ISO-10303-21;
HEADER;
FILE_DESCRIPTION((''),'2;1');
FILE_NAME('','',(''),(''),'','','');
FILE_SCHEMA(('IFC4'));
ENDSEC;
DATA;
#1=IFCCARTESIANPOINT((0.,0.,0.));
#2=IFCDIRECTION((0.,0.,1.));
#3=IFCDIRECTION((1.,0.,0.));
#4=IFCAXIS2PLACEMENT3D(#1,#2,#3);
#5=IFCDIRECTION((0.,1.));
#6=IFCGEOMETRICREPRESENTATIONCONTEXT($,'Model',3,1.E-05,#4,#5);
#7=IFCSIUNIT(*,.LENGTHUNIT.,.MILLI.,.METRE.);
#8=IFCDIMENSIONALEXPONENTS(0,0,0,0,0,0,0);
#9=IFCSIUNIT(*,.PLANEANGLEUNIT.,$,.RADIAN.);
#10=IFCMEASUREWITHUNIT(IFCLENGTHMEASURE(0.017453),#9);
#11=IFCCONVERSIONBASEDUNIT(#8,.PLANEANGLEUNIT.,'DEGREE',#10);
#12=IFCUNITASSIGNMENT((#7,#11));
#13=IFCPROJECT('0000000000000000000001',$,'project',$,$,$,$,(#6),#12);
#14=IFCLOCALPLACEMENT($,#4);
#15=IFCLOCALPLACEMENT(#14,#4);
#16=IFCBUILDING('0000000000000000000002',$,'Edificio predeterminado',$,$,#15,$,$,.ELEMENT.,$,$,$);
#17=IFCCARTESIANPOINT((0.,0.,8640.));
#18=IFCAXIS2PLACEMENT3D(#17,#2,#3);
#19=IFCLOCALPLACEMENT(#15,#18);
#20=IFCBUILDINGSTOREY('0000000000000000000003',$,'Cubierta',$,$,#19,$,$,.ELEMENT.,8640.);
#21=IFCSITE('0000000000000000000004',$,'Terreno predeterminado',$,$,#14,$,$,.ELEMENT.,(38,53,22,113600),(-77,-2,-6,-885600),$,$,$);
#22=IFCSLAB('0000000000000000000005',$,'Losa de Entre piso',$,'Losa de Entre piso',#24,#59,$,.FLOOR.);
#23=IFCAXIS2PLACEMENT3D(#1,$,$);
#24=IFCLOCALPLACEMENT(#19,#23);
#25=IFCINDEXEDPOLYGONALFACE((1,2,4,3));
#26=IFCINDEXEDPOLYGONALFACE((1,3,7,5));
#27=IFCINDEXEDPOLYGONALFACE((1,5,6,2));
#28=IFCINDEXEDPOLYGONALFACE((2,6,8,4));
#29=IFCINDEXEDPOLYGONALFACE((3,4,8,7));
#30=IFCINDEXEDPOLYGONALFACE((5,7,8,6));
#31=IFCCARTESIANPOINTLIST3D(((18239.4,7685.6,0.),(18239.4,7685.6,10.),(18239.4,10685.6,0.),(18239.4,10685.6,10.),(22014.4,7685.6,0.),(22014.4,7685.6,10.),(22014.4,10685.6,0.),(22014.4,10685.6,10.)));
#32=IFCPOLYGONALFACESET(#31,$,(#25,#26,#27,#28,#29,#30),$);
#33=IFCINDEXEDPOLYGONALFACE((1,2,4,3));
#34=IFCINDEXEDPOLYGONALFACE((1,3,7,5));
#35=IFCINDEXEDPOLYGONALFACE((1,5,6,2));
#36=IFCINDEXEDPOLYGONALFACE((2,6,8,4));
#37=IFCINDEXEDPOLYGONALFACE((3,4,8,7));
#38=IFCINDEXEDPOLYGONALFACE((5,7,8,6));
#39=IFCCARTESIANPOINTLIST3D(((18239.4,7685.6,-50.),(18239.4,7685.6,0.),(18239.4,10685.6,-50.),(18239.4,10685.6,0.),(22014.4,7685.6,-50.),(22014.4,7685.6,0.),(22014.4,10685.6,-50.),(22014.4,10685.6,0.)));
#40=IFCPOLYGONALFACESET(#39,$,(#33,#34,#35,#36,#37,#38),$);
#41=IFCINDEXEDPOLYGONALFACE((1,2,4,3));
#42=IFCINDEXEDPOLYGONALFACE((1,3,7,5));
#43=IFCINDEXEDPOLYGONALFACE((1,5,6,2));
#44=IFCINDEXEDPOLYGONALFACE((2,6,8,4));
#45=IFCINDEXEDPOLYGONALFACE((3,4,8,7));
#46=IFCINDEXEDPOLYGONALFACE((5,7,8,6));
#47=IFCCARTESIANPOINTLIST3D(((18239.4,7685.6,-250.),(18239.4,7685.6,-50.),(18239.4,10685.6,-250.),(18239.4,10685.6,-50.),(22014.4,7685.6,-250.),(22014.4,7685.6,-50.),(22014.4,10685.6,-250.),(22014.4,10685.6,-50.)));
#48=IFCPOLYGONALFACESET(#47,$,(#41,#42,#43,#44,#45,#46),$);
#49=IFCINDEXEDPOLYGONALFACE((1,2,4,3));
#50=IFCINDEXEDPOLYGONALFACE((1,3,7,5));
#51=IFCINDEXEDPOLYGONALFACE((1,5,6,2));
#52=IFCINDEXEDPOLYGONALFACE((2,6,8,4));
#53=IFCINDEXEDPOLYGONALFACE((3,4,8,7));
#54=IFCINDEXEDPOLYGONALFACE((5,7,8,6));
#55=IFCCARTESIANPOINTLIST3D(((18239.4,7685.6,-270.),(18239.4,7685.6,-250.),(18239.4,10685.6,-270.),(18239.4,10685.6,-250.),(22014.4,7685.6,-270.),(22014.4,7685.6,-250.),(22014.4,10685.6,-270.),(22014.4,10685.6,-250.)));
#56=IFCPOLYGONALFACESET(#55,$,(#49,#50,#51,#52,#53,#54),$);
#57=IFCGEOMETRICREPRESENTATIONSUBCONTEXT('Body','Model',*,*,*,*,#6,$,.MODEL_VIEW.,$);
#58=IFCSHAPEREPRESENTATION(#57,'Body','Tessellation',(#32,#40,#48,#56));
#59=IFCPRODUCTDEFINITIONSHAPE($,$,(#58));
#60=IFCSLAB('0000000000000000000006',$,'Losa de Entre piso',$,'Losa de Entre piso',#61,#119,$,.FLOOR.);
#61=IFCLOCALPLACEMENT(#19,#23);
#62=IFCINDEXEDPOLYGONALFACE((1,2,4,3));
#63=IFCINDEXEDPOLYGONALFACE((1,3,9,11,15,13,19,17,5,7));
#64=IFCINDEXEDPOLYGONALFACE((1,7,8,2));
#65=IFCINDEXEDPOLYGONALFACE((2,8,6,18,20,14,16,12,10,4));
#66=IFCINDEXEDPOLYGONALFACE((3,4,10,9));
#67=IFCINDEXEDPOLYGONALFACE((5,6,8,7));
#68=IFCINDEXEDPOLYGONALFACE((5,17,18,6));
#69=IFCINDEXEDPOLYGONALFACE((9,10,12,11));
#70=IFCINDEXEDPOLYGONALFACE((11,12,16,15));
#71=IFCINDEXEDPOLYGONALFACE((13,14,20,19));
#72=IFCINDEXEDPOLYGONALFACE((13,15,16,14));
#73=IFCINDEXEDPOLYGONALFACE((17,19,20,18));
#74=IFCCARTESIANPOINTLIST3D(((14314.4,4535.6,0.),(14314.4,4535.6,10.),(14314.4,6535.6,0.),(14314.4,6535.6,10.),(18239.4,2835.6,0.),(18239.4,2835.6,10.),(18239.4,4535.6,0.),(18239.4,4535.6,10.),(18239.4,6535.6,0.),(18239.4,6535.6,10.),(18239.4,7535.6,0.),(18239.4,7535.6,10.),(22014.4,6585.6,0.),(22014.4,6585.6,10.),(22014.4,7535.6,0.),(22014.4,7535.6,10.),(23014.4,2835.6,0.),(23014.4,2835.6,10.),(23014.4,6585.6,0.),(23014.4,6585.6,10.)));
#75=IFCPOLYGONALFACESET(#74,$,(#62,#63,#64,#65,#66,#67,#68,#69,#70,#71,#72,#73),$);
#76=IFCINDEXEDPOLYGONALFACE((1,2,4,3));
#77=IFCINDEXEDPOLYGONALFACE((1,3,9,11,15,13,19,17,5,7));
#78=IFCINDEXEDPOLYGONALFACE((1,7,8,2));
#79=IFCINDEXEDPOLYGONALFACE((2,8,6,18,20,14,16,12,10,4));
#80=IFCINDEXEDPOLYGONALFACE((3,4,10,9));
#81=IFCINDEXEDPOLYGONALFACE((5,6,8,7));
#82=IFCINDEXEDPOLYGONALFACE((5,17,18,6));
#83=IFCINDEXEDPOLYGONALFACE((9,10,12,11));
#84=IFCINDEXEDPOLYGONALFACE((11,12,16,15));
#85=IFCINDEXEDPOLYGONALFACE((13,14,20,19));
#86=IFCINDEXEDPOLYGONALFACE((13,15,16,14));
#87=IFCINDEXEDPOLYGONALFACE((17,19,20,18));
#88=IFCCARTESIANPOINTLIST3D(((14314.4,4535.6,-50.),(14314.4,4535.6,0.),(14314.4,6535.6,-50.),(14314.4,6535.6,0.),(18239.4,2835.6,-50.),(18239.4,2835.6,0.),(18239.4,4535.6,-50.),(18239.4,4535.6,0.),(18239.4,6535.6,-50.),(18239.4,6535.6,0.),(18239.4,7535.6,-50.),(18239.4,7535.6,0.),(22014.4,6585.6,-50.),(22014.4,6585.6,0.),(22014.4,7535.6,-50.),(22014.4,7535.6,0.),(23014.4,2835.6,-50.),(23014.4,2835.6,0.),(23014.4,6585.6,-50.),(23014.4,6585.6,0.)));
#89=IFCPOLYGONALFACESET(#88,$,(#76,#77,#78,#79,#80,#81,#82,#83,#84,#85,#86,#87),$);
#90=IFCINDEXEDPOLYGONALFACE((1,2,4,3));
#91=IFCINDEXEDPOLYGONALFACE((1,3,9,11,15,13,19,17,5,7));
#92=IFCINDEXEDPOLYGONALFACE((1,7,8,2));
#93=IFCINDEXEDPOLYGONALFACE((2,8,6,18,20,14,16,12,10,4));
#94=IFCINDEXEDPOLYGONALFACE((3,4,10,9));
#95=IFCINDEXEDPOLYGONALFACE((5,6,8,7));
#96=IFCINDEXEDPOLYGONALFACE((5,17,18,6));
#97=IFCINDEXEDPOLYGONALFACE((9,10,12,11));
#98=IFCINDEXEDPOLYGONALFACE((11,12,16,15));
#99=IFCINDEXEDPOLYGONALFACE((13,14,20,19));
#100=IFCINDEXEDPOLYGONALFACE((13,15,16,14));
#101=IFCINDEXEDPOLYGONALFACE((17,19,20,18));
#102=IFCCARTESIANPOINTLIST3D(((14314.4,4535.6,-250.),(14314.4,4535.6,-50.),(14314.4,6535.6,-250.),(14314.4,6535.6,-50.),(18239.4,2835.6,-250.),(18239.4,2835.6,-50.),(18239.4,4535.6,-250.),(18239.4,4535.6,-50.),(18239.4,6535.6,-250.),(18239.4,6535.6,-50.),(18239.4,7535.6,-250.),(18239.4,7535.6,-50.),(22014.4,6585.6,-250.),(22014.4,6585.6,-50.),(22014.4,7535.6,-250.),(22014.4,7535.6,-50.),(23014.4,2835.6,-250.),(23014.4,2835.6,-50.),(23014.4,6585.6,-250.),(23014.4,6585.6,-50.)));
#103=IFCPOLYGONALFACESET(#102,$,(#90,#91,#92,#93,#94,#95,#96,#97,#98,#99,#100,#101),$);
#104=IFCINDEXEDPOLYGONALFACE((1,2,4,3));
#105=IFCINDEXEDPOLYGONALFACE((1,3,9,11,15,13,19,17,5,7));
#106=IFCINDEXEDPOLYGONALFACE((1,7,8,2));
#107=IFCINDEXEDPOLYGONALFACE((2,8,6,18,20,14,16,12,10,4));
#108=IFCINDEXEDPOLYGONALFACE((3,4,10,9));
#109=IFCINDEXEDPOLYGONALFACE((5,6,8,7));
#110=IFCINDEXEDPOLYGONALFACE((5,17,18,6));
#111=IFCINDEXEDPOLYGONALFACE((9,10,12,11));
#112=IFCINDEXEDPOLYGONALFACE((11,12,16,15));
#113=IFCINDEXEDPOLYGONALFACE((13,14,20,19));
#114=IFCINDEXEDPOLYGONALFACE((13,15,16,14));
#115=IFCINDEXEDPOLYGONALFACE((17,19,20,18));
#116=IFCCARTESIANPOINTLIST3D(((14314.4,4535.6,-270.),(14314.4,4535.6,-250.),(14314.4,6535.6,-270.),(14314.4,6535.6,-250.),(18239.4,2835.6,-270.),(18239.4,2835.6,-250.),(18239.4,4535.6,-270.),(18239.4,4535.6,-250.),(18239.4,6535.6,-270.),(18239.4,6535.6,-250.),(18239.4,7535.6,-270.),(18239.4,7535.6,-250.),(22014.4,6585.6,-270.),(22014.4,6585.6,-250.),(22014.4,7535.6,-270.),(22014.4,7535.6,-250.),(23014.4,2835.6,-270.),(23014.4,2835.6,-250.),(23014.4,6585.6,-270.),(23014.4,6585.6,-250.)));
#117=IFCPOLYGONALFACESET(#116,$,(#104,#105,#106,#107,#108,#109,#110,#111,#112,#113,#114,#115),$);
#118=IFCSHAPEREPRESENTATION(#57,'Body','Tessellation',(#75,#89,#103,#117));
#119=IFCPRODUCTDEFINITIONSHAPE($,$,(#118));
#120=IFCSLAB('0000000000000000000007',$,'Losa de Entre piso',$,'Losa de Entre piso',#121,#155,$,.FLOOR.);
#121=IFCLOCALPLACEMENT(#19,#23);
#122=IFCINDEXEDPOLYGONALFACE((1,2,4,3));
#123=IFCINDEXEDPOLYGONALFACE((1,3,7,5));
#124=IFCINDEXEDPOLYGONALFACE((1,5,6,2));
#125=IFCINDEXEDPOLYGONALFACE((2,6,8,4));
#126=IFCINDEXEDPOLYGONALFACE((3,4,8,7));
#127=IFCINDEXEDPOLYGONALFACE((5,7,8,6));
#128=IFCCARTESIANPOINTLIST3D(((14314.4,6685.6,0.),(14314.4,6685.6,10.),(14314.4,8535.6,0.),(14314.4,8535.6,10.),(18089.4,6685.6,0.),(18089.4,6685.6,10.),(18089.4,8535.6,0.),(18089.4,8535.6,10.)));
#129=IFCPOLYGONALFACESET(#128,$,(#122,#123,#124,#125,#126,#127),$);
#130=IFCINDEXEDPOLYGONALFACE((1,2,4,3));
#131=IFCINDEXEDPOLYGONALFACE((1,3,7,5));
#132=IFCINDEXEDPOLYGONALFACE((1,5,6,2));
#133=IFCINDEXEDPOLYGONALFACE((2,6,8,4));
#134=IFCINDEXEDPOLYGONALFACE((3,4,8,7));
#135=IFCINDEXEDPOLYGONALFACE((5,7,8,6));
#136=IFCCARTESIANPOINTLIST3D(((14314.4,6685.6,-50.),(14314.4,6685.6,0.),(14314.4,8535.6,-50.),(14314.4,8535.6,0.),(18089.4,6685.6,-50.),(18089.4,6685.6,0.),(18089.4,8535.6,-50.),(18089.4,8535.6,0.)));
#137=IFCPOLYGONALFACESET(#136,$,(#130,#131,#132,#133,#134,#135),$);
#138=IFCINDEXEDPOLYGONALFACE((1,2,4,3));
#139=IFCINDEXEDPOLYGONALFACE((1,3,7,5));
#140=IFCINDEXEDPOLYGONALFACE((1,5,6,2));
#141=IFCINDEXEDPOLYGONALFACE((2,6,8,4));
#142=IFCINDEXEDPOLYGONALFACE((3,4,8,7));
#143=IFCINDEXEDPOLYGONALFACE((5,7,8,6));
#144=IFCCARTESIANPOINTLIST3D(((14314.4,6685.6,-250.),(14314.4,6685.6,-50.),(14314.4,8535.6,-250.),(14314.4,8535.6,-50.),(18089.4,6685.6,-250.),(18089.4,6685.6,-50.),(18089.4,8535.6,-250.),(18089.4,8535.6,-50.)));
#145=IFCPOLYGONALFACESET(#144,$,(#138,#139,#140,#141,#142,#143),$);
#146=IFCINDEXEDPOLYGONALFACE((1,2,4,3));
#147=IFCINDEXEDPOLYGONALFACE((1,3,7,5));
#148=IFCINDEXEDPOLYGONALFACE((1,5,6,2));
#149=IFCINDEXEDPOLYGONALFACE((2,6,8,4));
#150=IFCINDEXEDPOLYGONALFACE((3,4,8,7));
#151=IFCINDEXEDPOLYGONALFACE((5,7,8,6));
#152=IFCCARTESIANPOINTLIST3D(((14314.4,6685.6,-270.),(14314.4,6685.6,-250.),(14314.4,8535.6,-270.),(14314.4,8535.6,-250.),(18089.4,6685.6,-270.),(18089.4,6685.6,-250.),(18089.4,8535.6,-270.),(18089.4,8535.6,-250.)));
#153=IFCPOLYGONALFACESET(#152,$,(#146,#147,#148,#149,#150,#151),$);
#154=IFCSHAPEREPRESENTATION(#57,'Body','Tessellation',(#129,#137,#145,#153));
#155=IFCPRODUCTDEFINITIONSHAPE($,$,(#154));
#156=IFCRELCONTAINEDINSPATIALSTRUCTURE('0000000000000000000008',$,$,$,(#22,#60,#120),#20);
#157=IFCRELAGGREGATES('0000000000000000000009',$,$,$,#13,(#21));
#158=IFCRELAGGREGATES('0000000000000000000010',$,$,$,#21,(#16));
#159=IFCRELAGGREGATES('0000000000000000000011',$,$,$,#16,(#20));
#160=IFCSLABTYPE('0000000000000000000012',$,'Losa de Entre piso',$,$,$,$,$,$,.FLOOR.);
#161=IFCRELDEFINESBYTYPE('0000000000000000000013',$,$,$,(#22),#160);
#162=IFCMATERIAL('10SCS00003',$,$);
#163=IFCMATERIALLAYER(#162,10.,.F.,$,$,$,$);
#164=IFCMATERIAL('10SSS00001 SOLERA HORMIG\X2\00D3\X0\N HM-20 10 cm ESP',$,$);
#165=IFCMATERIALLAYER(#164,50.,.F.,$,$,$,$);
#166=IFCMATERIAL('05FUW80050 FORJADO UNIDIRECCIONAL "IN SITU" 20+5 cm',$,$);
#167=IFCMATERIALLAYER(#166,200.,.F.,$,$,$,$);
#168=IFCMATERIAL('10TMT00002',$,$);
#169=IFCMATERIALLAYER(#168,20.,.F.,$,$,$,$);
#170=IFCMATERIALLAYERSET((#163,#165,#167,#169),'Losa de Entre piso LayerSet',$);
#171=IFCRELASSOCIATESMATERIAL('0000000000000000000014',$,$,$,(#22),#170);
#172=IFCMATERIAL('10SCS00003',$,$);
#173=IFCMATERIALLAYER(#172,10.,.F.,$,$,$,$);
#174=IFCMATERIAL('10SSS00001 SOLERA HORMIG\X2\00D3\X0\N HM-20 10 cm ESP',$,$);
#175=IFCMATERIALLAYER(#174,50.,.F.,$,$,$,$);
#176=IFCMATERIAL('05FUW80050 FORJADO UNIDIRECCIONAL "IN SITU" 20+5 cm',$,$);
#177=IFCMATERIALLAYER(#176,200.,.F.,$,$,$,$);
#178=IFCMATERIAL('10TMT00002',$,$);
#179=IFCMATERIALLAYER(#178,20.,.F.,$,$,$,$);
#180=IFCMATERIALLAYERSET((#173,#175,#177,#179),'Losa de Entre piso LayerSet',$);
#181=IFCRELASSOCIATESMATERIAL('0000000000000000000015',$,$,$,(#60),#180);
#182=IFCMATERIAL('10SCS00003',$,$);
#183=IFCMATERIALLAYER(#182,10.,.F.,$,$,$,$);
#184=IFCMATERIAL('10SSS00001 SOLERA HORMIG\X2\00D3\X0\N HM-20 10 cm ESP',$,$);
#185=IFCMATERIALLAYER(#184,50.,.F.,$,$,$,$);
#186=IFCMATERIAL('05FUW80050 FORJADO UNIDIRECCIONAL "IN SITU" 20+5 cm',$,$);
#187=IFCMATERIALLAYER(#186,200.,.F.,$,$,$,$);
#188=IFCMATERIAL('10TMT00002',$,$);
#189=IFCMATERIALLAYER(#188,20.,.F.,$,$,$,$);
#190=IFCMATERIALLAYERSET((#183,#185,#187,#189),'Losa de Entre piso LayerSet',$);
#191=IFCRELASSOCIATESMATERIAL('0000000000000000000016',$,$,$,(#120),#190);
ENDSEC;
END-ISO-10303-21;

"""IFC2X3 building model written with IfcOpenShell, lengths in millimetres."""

from ifc_helpers import new_model, entity, si_unit, converted_unit, direction, frame, origin_with_axes, place, context, subcontext, project, spatial, polyline, outline, extrude, material, layer, layer_set, layer_usage, type_object, element, save


model = new_model("IFC2X3")

# Units and contexts
model_context = context("Model", 3, precision=1e-05, world=origin_with_axes(), true_north=direction((0.0, 1.0)))
body_context = subcontext(model_context, "Body", "Model", "MODEL_VIEW")
ifc_project = project(units=[si_unit("LENGTHUNIT", "METRE", prefix="MILLI"), converted_unit("PLANEANGLEUNIT", "DEGREE", entity("IfcLengthMeasure", 0.017453), si_unit("PLANEANGLEUNIT", "RADIAN"), dimensions=[0, 0, 0, 0, 0, 0, 0])], contexts=[model_context])

# Site, building, storey
site_placement = place(None, origin_with_axes())
site = spatial("IfcSite", under=ifc_project, at=site_placement, Name="Terreno predeterminado", CompositionType="ELEMENT", RefLatitude=(38, 53, 22, 113600), RefLongitude=(-77, -2, -6, -885600))
building_placement = place(site_placement, origin_with_axes())
building = spatial("IfcBuilding", under=site, at=building_placement, Name="Edificio predeterminado", CompositionType="ELEMENT")
storey_placement = place(building_placement, frame((0.0, 0.0, 8640.0), z_axis=(0.0, 0.0, 1.0), x_axis=(1.0, 0.0, 0.0)))
storey = spatial("IfcBuildingStorey", under=building, at=storey_placement, Name="Cubierta", CompositionType="ELEMENT", Elevation=8640.0)

# Slabs
ifc_material_1 = material(Name="10SCS00003")
ifc_layer_1 = layer(ifc_material_1, 10.0, ventilated=False)
ifc_material_2 = material(Name="10SSS00001 SOLERA HORMIGÓN HM-20 10 cm ESP")
ifc_layer_2 = layer(ifc_material_2, 50.0, ventilated=False)
ifc_material_3 = material(Name="05FUW80050 FORJADO UNIDIRECCIONAL \"IN SITU\" 20+5 cm")
ifc_layer_3 = layer(ifc_material_3, 200.0, ventilated=False)
ifc_material_4 = material(Name="10TMT00002")
ifc_layer_4 = layer(ifc_material_4, 20.0, ventilated=False)
ifc_layer_set_1 = layer_set([ifc_layer_1, ifc_layer_2, ifc_layer_3, ifc_layer_4], Name="Losa de Entre piso LayerSet")
ifc_layer_usage_1 = layer_usage(ifc_layer_set_1, "AXIS3", "NEGATIVE", 0.0)
slab_type = type_object("IfcSlabType", Name="Losa de Entre piso", PredefinedType="FLOOR")
slab_1_placement = place(storey_placement, frame((0.0, 0.0, -8640.0), z_axis=(0.0, 0.0, 1.0), x_axis=(1.0, 0.0, 0.0)))
element("IfcSlab", 1, at=slab_1_placement, inside=storey, type_object=slab_type, material=ifc_layer_usage_1, Name="Losa de Entre piso", ObjectType="Losa de Entre piso", PredefinedType="FLOOR", context=body_context, shape_type="SweptSolid", body=[
    extrude(outline(polyline([(0.0, 3000.0), (3775.0, 3000.0), (3775.0, 0.0), (0.0, 0.0), (0.0, 3000.0)])), frame((22014.4, 7685.6, 8640.0), z_axis=(0.0, 0.0, -1.0), x_axis=(-1.0, 0.0, 0.0)), (0.0, 0.0, -1.0), 10.0),
    extrude(outline(polyline([(0.0, 3000.0), (3775.0, 3000.0), (3775.0, 0.0), (0.0, 0.0), (0.0, 3000.0)])), frame((22014.4, 7685.6, 8590.0), z_axis=(0.0, 0.0, -1.0), x_axis=(-1.0, 0.0, 0.0)), (0.0, 0.0, -1.0), 50.0),
    extrude(outline(polyline([(0.0, 3000.0), (3775.0, 3000.0), (3775.0, 0.0), (0.0, 0.0), (0.0, 3000.0)])), frame((22014.4, 7685.6, 8390.0), z_axis=(0.0, 0.0, -1.0), x_axis=(-1.0, 0.0, 0.0)), (0.0, 0.0, -1.0), 200.0),
    extrude(outline(polyline([(0.0, 3000.0), (3775.0, 3000.0), (3775.0, 0.0), (0.0, 0.0), (0.0, 3000.0)])), frame((22014.4, 7685.6, 8370.0), z_axis=(0.0, 0.0, -1.0), x_axis=(-1.0, 0.0, 0.0)), (0.0, 0.0, -1.0), 20.0),
])
ifc_material_5 = material(Name="10SCS00003")
ifc_layer_5 = layer(ifc_material_5, 10.0, ventilated=False)
ifc_material_6 = material(Name="10SSS00001 SOLERA HORMIGÓN HM-20 10 cm ESP")
ifc_layer_6 = layer(ifc_material_6, 50.0, ventilated=False)
ifc_material_7 = material(Name="05FUW80050 FORJADO UNIDIRECCIONAL \"IN SITU\" 20+5 cm")
ifc_layer_7 = layer(ifc_material_7, 200.0, ventilated=False)
ifc_material_8 = material(Name="10TMT00002")
ifc_layer_8 = layer(ifc_material_8, 20.0, ventilated=False)
ifc_layer_set_2 = layer_set([ifc_layer_5, ifc_layer_6, ifc_layer_7, ifc_layer_8], Name="Losa de Entre piso LayerSet")
ifc_layer_usage_2 = layer_usage(ifc_layer_set_2, "AXIS3", "NEGATIVE", 0.0)
slab_2_placement = place(storey_placement, frame((0.0, 0.0, -8640.0), z_axis=(0.0, 0.0, 1.0), x_axis=(1.0, 0.0, 0.0)))
element("IfcSlab", 2, at=slab_2_placement, inside=storey, material=ifc_layer_usage_2, Name="Losa de Entre piso", ObjectType="Losa de Entre piso", PredefinedType="FLOOR", context=body_context, shape_type="SweptSolid", body=[
    extrude(outline(polyline([(0.0, 1000.0), (-3925.0, 1000.0), (-3925.0, 3000.0), (0.0, 3000.0), (0.0, 4700.0), (4775.0, 4700.0), (4775.0, 950.0), (3775.0, 950.0), (3775.0, 0.0), (0.0, 0.0), (0.0, 1000.0)])), frame((18239.4, 7535.6, 8640.0), z_axis=(0.0, 0.0, -1.0), x_axis=(1.0, 0.0, 0.0)), (0.0, 0.0, -1.0), 10.0),
    extrude(outline(polyline([(0.0, 1000.0), (-3925.0, 1000.0), (-3925.0, 3000.0), (0.0, 3000.0), (0.0, 4700.0), (4775.0, 4700.0), (4775.0, 950.0), (3775.0, 950.0), (3775.0, 0.0), (0.0, 0.0), (0.0, 1000.0)])), frame((18239.4, 7535.6, 8590.0), z_axis=(0.0, 0.0, -1.0), x_axis=(1.0, 0.0, 0.0)), (0.0, 0.0, -1.0), 50.0),
    extrude(outline(polyline([(0.0, 1000.0), (-3925.0, 1000.0), (-3925.0, 3000.0), (0.0, 3000.0), (0.0, 4700.0), (4775.0, 4700.0), (4775.0, 950.0), (3775.0, 950.0), (3775.0, 0.0), (0.0, 0.0), (0.0, 1000.0)])), frame((18239.4, 7535.6, 8390.0), z_axis=(0.0, 0.0, -1.0), x_axis=(1.0, 0.0, 0.0)), (0.0, 0.0, -1.0), 200.0),
    extrude(outline(polyline([(0.0, 1000.0), (-3925.0, 1000.0), (-3925.0, 3000.0), (0.0, 3000.0), (0.0, 4700.0), (4775.0, 4700.0), (4775.0, 950.0), (3775.0, 950.0), (3775.0, 0.0), (0.0, 0.0), (0.0, 1000.0)])), frame((18239.4, 7535.6, 8370.0), z_axis=(0.0, 0.0, -1.0), x_axis=(1.0, 0.0, 0.0)), (0.0, 0.0, -1.0), 20.0),
])
ifc_material_9 = material(Name="10SCS00003")
ifc_layer_9 = layer(ifc_material_9, 10.0, ventilated=False)
ifc_material_10 = material(Name="10SSS00001 SOLERA HORMIGÓN HM-20 10 cm ESP")
ifc_layer_10 = layer(ifc_material_10, 50.0, ventilated=False)
ifc_material_11 = material(Name="05FUW80050 FORJADO UNIDIRECCIONAL \"IN SITU\" 20+5 cm")
ifc_layer_11 = layer(ifc_material_11, 200.0, ventilated=False)
ifc_material_12 = material(Name="10TMT00002")
ifc_layer_12 = layer(ifc_material_12, 20.0, ventilated=False)
ifc_layer_set_3 = layer_set([ifc_layer_9, ifc_layer_10, ifc_layer_11, ifc_layer_12], Name="Losa de Entre piso LayerSet")
ifc_layer_usage_3 = layer_usage(ifc_layer_set_3, "AXIS3", "NEGATIVE", 0.0)
slab_3_placement = place(storey_placement, frame((0.0, 0.0, -8640.0), z_axis=(0.0, 0.0, 1.0), x_axis=(1.0, 0.0, 0.0)))
element("IfcSlab", 3, at=slab_3_placement, inside=storey, material=ifc_layer_usage_3, Name="Losa de Entre piso", ObjectType="Losa de Entre piso", PredefinedType="FLOOR", context=body_context, shape_type="SweptSolid", body=[
    extrude(outline(polyline([(0.0, 1850.0), (3775.0, 1850.0), (3775.0, 0.0), (0.0, 0.0), (0.0, 1850.0)])), frame((18089.4, 6685.6, 8640.0), z_axis=(0.0, 0.0, -1.0), x_axis=(-1.0, 0.0, 0.0)), (0.0, 0.0, -1.0), 10.0),
    extrude(outline(polyline([(0.0, 1850.0), (3775.0, 1850.0), (3775.0, 0.0), (0.0, 0.0), (0.0, 1850.0)])), frame((18089.4, 6685.6, 8590.0), z_axis=(0.0, 0.0, -1.0), x_axis=(-1.0, 0.0, 0.0)), (0.0, 0.0, -1.0), 50.0),
    extrude(outline(polyline([(0.0, 1850.0), (3775.0, 1850.0), (3775.0, 0.0), (0.0, 0.0), (0.0, 1850.0)])), frame((18089.4, 6685.6, 8390.0), z_axis=(0.0, 0.0, -1.0), x_axis=(-1.0, 0.0, 0.0)), (0.0, 0.0, -1.0), 200.0),
    extrude(outline(polyline([(0.0, 1850.0), (3775.0, 1850.0), (3775.0, 0.0), (0.0, 0.0), (0.0, 1850.0)])), frame((18089.4, 6685.6, 8370.0), z_axis=(0.0, 0.0, -1.0), x_axis=(-1.0, 0.0, 0.0)), (0.0, 0.0, -1.0), 20.0),
])

save(model, "model.ifc")
